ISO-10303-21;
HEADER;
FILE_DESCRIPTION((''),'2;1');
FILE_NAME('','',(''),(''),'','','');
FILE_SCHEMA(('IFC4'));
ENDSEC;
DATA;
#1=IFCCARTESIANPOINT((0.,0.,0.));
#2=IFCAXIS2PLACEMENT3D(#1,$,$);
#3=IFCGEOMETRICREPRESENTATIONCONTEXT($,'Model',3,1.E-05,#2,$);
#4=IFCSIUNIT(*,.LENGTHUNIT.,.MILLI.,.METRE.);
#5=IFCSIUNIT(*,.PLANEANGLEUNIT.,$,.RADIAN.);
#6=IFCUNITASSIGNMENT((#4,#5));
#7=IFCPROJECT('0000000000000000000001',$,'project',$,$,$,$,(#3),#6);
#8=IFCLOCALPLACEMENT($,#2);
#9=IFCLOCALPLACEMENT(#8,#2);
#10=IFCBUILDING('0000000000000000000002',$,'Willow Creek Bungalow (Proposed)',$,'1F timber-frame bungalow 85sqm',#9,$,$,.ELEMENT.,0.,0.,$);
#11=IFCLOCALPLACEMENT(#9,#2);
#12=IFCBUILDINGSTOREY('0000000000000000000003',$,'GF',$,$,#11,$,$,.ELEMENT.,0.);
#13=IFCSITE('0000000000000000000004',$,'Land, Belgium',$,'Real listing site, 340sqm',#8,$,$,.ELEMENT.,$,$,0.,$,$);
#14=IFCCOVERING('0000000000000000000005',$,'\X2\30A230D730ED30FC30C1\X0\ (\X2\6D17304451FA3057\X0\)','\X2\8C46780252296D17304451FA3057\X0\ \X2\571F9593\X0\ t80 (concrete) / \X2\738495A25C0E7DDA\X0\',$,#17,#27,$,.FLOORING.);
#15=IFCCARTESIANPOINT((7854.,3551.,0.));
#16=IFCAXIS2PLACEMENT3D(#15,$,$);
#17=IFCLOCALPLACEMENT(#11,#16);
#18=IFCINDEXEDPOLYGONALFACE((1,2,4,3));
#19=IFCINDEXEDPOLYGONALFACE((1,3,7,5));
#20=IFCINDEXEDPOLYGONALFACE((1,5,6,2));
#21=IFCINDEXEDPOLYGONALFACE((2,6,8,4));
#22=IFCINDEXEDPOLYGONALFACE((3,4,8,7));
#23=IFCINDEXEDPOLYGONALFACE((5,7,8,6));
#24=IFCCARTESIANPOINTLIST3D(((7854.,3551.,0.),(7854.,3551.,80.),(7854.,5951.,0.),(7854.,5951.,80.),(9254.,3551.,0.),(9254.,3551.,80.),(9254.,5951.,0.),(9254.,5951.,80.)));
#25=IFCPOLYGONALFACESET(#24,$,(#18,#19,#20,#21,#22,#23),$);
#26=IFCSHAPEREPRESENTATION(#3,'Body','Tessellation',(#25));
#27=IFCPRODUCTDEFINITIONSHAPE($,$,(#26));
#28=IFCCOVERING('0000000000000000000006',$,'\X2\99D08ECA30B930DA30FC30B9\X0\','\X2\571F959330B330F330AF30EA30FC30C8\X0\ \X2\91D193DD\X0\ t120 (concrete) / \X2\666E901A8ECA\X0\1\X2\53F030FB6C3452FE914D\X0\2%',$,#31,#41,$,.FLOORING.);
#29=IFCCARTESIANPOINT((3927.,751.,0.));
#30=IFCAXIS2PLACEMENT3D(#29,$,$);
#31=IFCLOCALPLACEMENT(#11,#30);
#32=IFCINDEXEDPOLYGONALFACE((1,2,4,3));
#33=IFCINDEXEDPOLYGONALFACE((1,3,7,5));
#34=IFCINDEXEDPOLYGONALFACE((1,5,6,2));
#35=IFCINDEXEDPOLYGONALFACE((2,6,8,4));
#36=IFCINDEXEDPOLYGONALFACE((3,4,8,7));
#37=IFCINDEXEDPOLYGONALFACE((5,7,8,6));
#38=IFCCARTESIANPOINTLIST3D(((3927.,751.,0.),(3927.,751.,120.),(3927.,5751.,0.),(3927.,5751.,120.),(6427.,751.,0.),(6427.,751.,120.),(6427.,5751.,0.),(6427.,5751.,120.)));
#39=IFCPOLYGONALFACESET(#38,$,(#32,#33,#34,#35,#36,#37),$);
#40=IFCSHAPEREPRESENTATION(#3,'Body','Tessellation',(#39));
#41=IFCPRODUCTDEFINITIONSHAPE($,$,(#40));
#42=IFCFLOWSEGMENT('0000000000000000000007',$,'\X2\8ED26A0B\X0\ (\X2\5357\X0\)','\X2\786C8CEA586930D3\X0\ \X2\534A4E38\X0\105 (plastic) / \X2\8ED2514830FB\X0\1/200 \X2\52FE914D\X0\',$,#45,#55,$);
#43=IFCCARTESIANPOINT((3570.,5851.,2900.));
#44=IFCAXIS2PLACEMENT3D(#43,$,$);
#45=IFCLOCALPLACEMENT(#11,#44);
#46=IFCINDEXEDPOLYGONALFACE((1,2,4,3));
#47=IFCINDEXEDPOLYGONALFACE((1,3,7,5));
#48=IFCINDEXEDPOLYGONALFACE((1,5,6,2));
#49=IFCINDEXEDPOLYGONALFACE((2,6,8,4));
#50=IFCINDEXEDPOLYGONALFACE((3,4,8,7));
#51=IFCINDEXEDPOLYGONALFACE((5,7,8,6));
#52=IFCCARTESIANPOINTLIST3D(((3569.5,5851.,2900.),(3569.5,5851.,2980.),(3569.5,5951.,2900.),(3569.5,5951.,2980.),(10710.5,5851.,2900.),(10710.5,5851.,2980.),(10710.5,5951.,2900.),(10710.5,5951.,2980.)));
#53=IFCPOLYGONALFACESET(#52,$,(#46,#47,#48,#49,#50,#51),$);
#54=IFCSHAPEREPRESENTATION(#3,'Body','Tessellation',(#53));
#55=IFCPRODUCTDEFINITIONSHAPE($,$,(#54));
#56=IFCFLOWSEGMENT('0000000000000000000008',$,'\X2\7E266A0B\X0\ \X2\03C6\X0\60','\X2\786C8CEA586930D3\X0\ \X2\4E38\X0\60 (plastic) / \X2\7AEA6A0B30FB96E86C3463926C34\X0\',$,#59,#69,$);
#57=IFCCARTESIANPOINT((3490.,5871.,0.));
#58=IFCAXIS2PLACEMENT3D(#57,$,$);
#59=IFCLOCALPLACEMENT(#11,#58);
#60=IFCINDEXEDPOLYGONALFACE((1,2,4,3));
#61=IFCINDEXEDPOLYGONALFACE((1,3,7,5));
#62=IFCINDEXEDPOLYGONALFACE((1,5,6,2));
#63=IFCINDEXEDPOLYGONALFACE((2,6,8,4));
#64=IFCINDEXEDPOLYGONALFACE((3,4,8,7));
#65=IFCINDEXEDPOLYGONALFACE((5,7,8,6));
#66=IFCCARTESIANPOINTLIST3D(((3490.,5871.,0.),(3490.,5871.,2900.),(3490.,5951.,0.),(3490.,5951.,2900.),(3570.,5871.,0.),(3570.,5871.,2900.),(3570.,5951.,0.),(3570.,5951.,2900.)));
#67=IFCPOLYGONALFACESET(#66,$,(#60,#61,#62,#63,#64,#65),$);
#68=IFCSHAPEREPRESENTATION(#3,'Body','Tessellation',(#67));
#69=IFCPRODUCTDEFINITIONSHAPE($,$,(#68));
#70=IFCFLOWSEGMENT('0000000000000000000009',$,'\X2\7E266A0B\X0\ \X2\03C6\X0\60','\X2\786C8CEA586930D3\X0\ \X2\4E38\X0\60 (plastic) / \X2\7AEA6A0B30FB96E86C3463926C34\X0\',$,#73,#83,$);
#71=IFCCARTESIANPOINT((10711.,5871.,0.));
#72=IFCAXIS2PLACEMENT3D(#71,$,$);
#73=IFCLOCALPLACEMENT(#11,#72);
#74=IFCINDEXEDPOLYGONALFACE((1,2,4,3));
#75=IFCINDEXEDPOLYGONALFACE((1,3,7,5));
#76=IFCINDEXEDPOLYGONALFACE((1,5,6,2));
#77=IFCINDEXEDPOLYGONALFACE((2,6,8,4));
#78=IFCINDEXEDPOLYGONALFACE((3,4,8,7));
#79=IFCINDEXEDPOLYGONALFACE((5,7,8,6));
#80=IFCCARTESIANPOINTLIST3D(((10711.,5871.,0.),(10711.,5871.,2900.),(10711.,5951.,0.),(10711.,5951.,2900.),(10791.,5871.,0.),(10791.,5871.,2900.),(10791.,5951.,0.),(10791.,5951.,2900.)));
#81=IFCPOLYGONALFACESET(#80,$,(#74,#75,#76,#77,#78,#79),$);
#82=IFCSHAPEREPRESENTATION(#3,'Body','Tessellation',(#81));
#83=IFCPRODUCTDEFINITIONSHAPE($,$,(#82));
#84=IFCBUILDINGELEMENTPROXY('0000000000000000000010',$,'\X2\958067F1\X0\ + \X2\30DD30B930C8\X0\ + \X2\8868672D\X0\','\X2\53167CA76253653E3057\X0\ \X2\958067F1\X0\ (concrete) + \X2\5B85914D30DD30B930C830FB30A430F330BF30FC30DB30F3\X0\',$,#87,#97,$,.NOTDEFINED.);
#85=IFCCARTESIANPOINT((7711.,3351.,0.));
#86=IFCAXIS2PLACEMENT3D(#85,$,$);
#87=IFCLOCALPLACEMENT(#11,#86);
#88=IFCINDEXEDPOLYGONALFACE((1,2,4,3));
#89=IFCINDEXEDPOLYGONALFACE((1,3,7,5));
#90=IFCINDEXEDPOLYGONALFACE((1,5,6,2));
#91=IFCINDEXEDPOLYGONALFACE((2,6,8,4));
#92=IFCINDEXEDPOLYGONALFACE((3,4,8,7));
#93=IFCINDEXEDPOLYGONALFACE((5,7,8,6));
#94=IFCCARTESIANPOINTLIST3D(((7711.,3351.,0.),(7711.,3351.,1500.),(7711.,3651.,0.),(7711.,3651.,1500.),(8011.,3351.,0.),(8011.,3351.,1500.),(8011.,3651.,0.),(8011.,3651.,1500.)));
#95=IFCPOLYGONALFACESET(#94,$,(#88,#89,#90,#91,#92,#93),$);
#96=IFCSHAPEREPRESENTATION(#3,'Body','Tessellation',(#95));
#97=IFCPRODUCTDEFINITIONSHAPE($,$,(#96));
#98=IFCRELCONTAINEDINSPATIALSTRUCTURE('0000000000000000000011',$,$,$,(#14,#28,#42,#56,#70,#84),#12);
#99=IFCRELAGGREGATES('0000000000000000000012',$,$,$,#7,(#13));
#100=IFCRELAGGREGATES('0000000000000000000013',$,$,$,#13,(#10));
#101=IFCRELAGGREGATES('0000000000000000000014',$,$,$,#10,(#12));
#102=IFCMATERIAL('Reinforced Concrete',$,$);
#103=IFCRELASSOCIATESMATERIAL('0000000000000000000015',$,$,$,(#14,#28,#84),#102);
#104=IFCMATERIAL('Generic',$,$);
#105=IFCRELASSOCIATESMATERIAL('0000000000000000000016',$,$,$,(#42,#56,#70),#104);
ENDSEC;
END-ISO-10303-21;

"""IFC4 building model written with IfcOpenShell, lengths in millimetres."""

from ifc_helpers import new_model, si_unit, frame, frame_2d, origin, place, context, project, spatial, rectangle, extrude, material, element, save


model = new_model("IFC4")

# Units and contexts
model_context = context("Model", 3, precision=1e-05, world=origin())
ifc_project = project(units=[si_unit("LENGTHUNIT", "METRE", prefix="MILLI"), si_unit("PLANEANGLEUNIT", "RADIAN")], contexts=[model_context])

# Site, building, storey
site_placement = place(None, origin())
site = spatial("IfcSite", under=ifc_project, at=site_placement, Name="Land, Belgium", ObjectType="Real listing site, 340sqm", CompositionType="ELEMENT", RefElevation=0.0)
building_placement = place(site_placement, origin())
building = spatial("IfcBuilding", under=site, at=building_placement, Name="Willow Creek Bungalow (Proposed)", ObjectType="1F timber-frame bungalow 85sqm", CompositionType="ELEMENT", ElevationOfRefHeight=0.0, ElevationOfTerrain=0.0)
storey_placement = place(building_placement, origin())
storey = spatial("IfcBuildingStorey", under=building, at=storey_placement, Name="GF", CompositionType="ELEMENT", Elevation=0.0)

# Shared definitions
ifc_material_1 = material(Name="Reinforced Concrete")

# Coverings
covering_1_placement = place(storey_placement, frame((7854.0, 3551.0, 0.0)))
element("IfcCovering", 1, at=covering_1_placement, inside=storey, material=ifc_material_1, Name="アプローチ (洗い出し)", Description="豆砂利洗い出し 土間 t80 (concrete) / 玄関導線", PredefinedType="FLOORING", context=model_context, shape_type="SweptSolid", body=[
    extrude(rectangle(XDim=1400.0, YDim=2400.0, at=frame_2d((700.0, 1200.0))), frame((7854.0, 3551.0, 0.0)), (0.0, 0.0, 1.0), 80.0),
])
covering_2_placement = place(storey_placement, frame((3927.0, 751.0, 0.0)))
element("IfcCovering", 2, at=covering_2_placement, inside=storey, material=ifc_material_1, Name="駐車スペース", Description="土間コンクリート 金鏝 t120 (concrete) / 普通車1台・水勾配2%", PredefinedType="FLOORING", context=model_context, shape_type="SweptSolid", body=[
    extrude(rectangle(XDim=2500.0, YDim=5000.0, at=frame_2d((1250.0, 2500.0))), frame((3927.0, 751.0, 0.0)), (0.0, 0.0, 1.0), 120.0),
])

# Flow segments
ifc_material_2 = material(Name="Generic")
flow_segment_1_placement = place(storey_placement, frame((3570.0, 5851.0, 2900.0)))
element("IfcFlowSegment", 3, at=flow_segment_1_placement, inside=storey, material=ifc_material_2, Name="軒樋 (南)", Description="硬質塩ビ 半丸105 (plastic) / 軒先・1/200 勾配", context=model_context, shape_type="SweptSolid", body=[
    extrude(rectangle(XDim=7141.0, YDim=100.0, at=frame_2d((3570.0, 50.0))), frame((3570.0, 5851.0, 2900.0)), (0.0, 0.0, 1.0), 80.0),
])
flow_segment_2_placement = place(storey_placement, frame((3490.0, 5871.0, 0.0)))
element("IfcFlowSegment", 4, at=flow_segment_2_placement, inside=storey, material=ifc_material_2, Name="縦樋 φ60", Description="硬質塩ビ 丸60 (plastic) / 竪樋・雨水排水", context=model_context, shape_type="SweptSolid", body=[
    extrude(rectangle(XDim=80.0, YDim=80.0, at=frame_2d((40.0, 40.0))), frame((3490.0, 5871.0, 0.0)), (0.0, 0.0, 1.0), 2900.0),
])
flow_segment_3_placement = place(storey_placement, frame((10711.0, 5871.0, 0.0)))
element("IfcFlowSegment", 5, at=flow_segment_3_placement, inside=storey, material=ifc_material_2, Name="縦樋 φ60", Description="硬質塩ビ 丸60 (plastic) / 竪樋・雨水排水", context=model_context, shape_type="SweptSolid", body=[
    extrude(rectangle(XDim=80.0, YDim=80.0, at=frame_2d((40.0, 40.0))), frame((10711.0, 5871.0, 0.0)), (0.0, 0.0, 1.0), 2900.0),
])

# Building element proxy
proxy_placement = place(storey_placement, frame((7711.0, 3351.0, 0.0)))
element("IfcBuildingElementProxy", 6, at=proxy_placement, inside=storey, material=ifc_material_1, Name="門柱 + ポスト + 表札", Description="化粧打放し 門柱 (concrete) + 宅配ポスト・インターホン", PredefinedType="NOTDEFINED", context=model_context, shape_type="SweptSolid", body=[
    extrude(rectangle(XDim=300.0, YDim=300.0, at=frame_2d((150.0, 150.0))), frame((7711.0, 3351.0, 0.0)), (0.0, 0.0, 1.0), 1500.0),
])

save(model, "model.ifc")
